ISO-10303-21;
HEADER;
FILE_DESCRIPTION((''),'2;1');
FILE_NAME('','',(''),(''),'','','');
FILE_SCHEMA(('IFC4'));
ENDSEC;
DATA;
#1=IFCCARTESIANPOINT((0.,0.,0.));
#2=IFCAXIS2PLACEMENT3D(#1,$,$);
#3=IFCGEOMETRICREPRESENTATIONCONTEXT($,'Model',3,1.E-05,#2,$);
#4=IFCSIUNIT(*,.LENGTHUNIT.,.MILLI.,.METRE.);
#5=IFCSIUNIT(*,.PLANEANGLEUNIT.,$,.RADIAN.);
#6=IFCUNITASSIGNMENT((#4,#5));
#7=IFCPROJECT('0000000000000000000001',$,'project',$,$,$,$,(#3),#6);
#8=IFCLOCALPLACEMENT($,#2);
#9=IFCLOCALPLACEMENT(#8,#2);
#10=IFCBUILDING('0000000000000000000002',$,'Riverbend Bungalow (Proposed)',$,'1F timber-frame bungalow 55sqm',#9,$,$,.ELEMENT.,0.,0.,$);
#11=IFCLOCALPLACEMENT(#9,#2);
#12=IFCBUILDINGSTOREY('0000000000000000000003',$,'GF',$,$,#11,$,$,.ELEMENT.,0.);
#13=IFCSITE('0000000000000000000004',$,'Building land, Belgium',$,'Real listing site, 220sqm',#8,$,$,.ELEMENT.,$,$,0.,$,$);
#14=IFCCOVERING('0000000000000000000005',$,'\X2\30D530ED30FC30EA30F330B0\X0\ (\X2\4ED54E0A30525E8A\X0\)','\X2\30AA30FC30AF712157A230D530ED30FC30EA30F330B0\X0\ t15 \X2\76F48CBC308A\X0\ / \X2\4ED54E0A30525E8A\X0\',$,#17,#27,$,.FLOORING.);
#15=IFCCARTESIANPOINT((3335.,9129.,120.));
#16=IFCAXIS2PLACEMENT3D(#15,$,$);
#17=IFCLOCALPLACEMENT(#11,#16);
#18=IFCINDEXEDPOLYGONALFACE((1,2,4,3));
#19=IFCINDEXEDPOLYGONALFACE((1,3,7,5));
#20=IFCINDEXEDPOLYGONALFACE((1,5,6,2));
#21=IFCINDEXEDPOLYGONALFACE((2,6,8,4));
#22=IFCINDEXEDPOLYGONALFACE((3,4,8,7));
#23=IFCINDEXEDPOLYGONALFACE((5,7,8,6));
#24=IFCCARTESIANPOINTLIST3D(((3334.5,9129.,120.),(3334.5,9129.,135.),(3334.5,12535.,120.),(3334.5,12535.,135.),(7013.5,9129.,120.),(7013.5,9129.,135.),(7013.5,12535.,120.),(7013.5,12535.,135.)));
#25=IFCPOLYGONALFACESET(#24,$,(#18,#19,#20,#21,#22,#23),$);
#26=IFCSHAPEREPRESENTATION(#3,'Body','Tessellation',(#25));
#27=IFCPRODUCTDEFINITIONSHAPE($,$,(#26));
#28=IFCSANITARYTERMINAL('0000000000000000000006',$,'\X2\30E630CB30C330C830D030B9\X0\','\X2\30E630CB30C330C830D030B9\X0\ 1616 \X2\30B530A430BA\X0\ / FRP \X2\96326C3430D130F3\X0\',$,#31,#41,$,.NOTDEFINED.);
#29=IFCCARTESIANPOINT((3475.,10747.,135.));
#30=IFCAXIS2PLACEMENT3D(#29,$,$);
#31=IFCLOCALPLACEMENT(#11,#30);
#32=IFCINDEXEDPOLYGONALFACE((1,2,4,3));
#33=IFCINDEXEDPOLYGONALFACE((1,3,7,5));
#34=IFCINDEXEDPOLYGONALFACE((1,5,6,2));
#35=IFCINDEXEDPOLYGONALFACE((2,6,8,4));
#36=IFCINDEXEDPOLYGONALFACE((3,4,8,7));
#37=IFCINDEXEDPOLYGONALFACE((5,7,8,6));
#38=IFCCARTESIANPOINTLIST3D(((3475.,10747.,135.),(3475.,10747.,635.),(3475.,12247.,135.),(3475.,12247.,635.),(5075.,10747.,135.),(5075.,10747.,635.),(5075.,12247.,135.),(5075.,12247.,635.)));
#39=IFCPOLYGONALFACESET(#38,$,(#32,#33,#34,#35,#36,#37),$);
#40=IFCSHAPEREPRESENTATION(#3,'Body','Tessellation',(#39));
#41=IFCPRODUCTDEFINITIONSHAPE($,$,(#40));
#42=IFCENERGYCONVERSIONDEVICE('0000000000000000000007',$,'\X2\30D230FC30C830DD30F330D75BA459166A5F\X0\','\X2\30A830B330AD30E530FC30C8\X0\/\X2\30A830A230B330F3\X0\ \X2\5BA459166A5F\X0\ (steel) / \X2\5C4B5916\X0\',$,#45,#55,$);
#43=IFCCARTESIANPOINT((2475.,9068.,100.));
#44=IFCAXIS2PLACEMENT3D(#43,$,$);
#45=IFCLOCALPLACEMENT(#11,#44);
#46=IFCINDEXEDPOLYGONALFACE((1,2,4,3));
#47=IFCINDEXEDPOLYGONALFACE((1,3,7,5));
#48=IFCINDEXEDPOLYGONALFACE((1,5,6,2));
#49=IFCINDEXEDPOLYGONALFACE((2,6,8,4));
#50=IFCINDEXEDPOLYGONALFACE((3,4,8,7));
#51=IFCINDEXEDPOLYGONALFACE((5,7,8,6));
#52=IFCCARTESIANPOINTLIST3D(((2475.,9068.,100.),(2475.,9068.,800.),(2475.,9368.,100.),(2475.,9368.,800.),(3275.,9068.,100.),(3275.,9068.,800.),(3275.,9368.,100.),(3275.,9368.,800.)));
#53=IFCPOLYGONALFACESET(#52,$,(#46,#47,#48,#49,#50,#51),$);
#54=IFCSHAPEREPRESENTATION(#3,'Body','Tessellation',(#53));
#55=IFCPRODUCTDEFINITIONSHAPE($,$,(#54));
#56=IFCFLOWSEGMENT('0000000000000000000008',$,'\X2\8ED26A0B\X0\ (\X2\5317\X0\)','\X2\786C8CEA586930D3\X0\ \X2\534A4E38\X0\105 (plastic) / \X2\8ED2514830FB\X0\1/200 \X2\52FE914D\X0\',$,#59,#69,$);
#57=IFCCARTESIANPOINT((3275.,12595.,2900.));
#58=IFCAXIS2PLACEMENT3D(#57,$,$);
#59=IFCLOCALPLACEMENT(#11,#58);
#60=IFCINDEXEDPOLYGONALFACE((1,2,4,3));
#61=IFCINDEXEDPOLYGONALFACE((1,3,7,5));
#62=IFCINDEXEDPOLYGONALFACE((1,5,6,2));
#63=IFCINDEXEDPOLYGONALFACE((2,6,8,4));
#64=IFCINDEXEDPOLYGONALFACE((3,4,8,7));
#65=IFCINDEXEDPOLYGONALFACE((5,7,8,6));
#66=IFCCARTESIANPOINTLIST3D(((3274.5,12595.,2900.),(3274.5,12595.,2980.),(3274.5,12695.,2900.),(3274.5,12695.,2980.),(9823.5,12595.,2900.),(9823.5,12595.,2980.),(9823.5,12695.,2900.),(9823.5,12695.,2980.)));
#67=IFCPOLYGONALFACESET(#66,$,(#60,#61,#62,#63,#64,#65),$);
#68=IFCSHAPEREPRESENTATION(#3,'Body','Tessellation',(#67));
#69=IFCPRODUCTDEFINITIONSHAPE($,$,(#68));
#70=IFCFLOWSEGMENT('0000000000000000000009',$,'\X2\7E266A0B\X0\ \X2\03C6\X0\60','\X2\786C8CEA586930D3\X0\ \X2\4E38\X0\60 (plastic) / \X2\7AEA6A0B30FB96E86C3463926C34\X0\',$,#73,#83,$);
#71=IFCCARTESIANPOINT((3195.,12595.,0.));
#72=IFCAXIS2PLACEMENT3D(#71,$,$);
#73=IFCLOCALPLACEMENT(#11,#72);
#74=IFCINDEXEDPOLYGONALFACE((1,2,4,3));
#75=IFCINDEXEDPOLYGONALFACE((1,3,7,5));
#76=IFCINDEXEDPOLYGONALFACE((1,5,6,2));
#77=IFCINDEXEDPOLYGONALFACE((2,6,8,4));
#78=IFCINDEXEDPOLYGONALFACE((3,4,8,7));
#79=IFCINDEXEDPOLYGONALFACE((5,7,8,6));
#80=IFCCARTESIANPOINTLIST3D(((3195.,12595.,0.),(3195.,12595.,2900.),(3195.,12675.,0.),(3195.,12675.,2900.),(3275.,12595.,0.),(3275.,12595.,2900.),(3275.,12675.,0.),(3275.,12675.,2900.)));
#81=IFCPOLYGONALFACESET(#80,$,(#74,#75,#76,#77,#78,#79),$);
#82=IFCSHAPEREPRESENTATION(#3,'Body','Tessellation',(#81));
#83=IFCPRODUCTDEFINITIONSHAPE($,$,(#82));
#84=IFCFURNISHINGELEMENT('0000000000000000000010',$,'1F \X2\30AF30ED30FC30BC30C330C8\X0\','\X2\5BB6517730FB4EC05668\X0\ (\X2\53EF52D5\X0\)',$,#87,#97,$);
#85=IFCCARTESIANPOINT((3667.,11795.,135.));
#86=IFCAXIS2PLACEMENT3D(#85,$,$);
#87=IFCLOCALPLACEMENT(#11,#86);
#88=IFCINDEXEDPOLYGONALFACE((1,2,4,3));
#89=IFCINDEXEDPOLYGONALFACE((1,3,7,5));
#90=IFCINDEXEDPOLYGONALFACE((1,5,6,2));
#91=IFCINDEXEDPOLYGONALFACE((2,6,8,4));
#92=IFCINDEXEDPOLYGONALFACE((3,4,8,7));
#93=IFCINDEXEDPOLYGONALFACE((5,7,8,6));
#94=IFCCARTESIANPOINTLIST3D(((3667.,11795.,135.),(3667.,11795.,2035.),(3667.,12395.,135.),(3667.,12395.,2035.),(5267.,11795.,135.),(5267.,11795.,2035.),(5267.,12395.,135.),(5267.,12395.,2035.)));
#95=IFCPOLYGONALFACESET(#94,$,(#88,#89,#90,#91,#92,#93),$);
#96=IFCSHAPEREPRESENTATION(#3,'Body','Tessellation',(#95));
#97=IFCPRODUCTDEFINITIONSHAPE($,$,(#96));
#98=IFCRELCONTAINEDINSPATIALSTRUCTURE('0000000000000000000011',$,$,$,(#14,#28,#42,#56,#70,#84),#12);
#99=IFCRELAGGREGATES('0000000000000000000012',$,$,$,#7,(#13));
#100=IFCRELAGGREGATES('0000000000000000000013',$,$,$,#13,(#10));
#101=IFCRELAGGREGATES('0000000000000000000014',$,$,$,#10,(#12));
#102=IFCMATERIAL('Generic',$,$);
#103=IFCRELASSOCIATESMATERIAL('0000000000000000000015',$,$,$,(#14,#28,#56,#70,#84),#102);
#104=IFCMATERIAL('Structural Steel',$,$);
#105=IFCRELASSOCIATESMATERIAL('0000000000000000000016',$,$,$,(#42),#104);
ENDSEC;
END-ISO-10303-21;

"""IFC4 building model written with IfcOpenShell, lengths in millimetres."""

from ifc_helpers import new_model, si_unit, frame, frame_2d, origin, place, context, project, spatial, rectangle, extrude, material, element, save


model = new_model("IFC4")

# Units and contexts
model_context = context("Model", 3, precision=1e-05, world=origin())
ifc_project = project(units=[si_unit("LENGTHUNIT", "METRE", prefix="MILLI"), si_unit("PLANEANGLEUNIT", "RADIAN")], contexts=[model_context])

# Site, building, storey
site_placement = place(None, origin())
site = spatial("IfcSite", under=ifc_project, at=site_placement, Name="Building land, Belgium", ObjectType="Real listing site, 220sqm", CompositionType="ELEMENT", RefElevation=0.0)
building_placement = place(site_placement, origin())
building = spatial("IfcBuilding", under=site, at=building_placement, Name="Riverbend Bungalow (Proposed)", ObjectType="1F timber-frame bungalow 55sqm", CompositionType="ELEMENT", ElevationOfRefHeight=0.0, ElevationOfTerrain=0.0)
storey_placement = place(building_placement, origin())
storey = spatial("IfcBuildingStorey", under=building, at=storey_placement, Name="GF", CompositionType="ELEMENT", Elevation=0.0)

# Shared definitions
ifc_material_1 = material(Name="Structural Steel")

# Covering
ifc_material_2 = material(Name="Generic")
covering_placement = place(storey_placement, frame((3335.0, 9129.0, 120.0)))
element("IfcCovering", 1, at=covering_placement, inside=storey, material=ifc_material_2, Name="フローリング (仕上げ床)", Description="オーク無垢フローリング t15 直貼り / 仕上げ床", PredefinedType="FLOORING", context=model_context, shape_type="SweptSolid", body=[
    extrude(rectangle(XDim=3679.0, YDim=3406.0, at=frame_2d((1839.0, 1703.0))), frame((3335.0, 9129.0, 120.0)), (0.0, 0.0, 1.0), 15.0),
])

# Sanitary terminal
sanitary_terminal_placement = place(storey_placement, frame((3475.0, 10747.0, 135.0)))
element("IfcSanitaryTerminal", 2, at=sanitary_terminal_placement, inside=storey, material=ifc_material_2, Name="ユニットバス", Description="ユニットバス 1616 サイズ / FRP 防水パン", PredefinedType="NOTDEFINED", context=model_context, shape_type="SweptSolid", body=[
    extrude(rectangle(XDim=1600.0, YDim=1500.0, at=frame_2d((800.0, 750.0))), frame((3475.0, 10747.0, 135.0)), (0.0, 0.0, 1.0), 500.0),
])

# Energy conversion device
energy_conversion_device_placement = place(storey_placement, frame((2475.0, 9068.0, 100.0)))
element("IfcEnergyConversionDevice", 3, at=energy_conversion_device_placement, inside=storey, material=ifc_material_1, Name="ヒートポンプ室外機", Description="エコキュート/エアコン 室外機 (steel) / 屋外", context=model_context, shape_type="SweptSolid", body=[
    extrude(rectangle(XDim=800.0, YDim=300.0, at=frame_2d((400.0, 150.0))), frame((2475.0, 9068.0, 100.0)), (0.0, 0.0, 1.0), 700.0),
])

# Flow segments
flow_segment_1_placement = place(storey_placement, frame((3275.0, 12595.0, 2900.0)))
element("IfcFlowSegment", 4, at=flow_segment_1_placement, inside=storey, material=ifc_material_2, Name="軒樋 (北)", Description="硬質塩ビ 半丸105 (plastic) / 軒先・1/200 勾配", context=model_context, shape_type="SweptSolid", body=[
    extrude(rectangle(XDim=6549.0, YDim=100.0, at=frame_2d((3274.0, 50.0))), frame((3275.0, 12595.0, 2900.0)), (0.0, 0.0, 1.0), 80.0),
])
flow_segment_2_placement = place(storey_placement, frame((3195.0, 12595.0, 0.0)))
element("IfcFlowSegment", 5, at=flow_segment_2_placement, inside=storey, material=ifc_material_2, Name="縦樋 φ60", Description="硬質塩ビ 丸60 (plastic) / 竪樋・雨水排水", context=model_context, shape_type="SweptSolid", body=[
    extrude(rectangle(XDim=80.0, YDim=80.0, at=frame_2d((40.0, 40.0))), frame((3195.0, 12595.0, 0.0)), (0.0, 0.0, 1.0), 2900.0),
])

# Furnishing element
furnishing_placement = place(storey_placement, frame((3667.0, 11795.0, 135.0)))
element("IfcFurnishingElement", 6, at=furnishing_placement, inside=storey, material=ifc_material_2, Name="1F クローゼット", Description="家具・什器 (可動)", context=model_context, shape_type="SweptSolid", body=[
    extrude(rectangle(XDim=1600.0, YDim=600.0, at=frame_2d((800.0, 300.0))), frame((3667.0, 11795.0, 135.0)), (0.0, 0.0, 1.0), 1900.0),
])

save(model, "model.ifc")
